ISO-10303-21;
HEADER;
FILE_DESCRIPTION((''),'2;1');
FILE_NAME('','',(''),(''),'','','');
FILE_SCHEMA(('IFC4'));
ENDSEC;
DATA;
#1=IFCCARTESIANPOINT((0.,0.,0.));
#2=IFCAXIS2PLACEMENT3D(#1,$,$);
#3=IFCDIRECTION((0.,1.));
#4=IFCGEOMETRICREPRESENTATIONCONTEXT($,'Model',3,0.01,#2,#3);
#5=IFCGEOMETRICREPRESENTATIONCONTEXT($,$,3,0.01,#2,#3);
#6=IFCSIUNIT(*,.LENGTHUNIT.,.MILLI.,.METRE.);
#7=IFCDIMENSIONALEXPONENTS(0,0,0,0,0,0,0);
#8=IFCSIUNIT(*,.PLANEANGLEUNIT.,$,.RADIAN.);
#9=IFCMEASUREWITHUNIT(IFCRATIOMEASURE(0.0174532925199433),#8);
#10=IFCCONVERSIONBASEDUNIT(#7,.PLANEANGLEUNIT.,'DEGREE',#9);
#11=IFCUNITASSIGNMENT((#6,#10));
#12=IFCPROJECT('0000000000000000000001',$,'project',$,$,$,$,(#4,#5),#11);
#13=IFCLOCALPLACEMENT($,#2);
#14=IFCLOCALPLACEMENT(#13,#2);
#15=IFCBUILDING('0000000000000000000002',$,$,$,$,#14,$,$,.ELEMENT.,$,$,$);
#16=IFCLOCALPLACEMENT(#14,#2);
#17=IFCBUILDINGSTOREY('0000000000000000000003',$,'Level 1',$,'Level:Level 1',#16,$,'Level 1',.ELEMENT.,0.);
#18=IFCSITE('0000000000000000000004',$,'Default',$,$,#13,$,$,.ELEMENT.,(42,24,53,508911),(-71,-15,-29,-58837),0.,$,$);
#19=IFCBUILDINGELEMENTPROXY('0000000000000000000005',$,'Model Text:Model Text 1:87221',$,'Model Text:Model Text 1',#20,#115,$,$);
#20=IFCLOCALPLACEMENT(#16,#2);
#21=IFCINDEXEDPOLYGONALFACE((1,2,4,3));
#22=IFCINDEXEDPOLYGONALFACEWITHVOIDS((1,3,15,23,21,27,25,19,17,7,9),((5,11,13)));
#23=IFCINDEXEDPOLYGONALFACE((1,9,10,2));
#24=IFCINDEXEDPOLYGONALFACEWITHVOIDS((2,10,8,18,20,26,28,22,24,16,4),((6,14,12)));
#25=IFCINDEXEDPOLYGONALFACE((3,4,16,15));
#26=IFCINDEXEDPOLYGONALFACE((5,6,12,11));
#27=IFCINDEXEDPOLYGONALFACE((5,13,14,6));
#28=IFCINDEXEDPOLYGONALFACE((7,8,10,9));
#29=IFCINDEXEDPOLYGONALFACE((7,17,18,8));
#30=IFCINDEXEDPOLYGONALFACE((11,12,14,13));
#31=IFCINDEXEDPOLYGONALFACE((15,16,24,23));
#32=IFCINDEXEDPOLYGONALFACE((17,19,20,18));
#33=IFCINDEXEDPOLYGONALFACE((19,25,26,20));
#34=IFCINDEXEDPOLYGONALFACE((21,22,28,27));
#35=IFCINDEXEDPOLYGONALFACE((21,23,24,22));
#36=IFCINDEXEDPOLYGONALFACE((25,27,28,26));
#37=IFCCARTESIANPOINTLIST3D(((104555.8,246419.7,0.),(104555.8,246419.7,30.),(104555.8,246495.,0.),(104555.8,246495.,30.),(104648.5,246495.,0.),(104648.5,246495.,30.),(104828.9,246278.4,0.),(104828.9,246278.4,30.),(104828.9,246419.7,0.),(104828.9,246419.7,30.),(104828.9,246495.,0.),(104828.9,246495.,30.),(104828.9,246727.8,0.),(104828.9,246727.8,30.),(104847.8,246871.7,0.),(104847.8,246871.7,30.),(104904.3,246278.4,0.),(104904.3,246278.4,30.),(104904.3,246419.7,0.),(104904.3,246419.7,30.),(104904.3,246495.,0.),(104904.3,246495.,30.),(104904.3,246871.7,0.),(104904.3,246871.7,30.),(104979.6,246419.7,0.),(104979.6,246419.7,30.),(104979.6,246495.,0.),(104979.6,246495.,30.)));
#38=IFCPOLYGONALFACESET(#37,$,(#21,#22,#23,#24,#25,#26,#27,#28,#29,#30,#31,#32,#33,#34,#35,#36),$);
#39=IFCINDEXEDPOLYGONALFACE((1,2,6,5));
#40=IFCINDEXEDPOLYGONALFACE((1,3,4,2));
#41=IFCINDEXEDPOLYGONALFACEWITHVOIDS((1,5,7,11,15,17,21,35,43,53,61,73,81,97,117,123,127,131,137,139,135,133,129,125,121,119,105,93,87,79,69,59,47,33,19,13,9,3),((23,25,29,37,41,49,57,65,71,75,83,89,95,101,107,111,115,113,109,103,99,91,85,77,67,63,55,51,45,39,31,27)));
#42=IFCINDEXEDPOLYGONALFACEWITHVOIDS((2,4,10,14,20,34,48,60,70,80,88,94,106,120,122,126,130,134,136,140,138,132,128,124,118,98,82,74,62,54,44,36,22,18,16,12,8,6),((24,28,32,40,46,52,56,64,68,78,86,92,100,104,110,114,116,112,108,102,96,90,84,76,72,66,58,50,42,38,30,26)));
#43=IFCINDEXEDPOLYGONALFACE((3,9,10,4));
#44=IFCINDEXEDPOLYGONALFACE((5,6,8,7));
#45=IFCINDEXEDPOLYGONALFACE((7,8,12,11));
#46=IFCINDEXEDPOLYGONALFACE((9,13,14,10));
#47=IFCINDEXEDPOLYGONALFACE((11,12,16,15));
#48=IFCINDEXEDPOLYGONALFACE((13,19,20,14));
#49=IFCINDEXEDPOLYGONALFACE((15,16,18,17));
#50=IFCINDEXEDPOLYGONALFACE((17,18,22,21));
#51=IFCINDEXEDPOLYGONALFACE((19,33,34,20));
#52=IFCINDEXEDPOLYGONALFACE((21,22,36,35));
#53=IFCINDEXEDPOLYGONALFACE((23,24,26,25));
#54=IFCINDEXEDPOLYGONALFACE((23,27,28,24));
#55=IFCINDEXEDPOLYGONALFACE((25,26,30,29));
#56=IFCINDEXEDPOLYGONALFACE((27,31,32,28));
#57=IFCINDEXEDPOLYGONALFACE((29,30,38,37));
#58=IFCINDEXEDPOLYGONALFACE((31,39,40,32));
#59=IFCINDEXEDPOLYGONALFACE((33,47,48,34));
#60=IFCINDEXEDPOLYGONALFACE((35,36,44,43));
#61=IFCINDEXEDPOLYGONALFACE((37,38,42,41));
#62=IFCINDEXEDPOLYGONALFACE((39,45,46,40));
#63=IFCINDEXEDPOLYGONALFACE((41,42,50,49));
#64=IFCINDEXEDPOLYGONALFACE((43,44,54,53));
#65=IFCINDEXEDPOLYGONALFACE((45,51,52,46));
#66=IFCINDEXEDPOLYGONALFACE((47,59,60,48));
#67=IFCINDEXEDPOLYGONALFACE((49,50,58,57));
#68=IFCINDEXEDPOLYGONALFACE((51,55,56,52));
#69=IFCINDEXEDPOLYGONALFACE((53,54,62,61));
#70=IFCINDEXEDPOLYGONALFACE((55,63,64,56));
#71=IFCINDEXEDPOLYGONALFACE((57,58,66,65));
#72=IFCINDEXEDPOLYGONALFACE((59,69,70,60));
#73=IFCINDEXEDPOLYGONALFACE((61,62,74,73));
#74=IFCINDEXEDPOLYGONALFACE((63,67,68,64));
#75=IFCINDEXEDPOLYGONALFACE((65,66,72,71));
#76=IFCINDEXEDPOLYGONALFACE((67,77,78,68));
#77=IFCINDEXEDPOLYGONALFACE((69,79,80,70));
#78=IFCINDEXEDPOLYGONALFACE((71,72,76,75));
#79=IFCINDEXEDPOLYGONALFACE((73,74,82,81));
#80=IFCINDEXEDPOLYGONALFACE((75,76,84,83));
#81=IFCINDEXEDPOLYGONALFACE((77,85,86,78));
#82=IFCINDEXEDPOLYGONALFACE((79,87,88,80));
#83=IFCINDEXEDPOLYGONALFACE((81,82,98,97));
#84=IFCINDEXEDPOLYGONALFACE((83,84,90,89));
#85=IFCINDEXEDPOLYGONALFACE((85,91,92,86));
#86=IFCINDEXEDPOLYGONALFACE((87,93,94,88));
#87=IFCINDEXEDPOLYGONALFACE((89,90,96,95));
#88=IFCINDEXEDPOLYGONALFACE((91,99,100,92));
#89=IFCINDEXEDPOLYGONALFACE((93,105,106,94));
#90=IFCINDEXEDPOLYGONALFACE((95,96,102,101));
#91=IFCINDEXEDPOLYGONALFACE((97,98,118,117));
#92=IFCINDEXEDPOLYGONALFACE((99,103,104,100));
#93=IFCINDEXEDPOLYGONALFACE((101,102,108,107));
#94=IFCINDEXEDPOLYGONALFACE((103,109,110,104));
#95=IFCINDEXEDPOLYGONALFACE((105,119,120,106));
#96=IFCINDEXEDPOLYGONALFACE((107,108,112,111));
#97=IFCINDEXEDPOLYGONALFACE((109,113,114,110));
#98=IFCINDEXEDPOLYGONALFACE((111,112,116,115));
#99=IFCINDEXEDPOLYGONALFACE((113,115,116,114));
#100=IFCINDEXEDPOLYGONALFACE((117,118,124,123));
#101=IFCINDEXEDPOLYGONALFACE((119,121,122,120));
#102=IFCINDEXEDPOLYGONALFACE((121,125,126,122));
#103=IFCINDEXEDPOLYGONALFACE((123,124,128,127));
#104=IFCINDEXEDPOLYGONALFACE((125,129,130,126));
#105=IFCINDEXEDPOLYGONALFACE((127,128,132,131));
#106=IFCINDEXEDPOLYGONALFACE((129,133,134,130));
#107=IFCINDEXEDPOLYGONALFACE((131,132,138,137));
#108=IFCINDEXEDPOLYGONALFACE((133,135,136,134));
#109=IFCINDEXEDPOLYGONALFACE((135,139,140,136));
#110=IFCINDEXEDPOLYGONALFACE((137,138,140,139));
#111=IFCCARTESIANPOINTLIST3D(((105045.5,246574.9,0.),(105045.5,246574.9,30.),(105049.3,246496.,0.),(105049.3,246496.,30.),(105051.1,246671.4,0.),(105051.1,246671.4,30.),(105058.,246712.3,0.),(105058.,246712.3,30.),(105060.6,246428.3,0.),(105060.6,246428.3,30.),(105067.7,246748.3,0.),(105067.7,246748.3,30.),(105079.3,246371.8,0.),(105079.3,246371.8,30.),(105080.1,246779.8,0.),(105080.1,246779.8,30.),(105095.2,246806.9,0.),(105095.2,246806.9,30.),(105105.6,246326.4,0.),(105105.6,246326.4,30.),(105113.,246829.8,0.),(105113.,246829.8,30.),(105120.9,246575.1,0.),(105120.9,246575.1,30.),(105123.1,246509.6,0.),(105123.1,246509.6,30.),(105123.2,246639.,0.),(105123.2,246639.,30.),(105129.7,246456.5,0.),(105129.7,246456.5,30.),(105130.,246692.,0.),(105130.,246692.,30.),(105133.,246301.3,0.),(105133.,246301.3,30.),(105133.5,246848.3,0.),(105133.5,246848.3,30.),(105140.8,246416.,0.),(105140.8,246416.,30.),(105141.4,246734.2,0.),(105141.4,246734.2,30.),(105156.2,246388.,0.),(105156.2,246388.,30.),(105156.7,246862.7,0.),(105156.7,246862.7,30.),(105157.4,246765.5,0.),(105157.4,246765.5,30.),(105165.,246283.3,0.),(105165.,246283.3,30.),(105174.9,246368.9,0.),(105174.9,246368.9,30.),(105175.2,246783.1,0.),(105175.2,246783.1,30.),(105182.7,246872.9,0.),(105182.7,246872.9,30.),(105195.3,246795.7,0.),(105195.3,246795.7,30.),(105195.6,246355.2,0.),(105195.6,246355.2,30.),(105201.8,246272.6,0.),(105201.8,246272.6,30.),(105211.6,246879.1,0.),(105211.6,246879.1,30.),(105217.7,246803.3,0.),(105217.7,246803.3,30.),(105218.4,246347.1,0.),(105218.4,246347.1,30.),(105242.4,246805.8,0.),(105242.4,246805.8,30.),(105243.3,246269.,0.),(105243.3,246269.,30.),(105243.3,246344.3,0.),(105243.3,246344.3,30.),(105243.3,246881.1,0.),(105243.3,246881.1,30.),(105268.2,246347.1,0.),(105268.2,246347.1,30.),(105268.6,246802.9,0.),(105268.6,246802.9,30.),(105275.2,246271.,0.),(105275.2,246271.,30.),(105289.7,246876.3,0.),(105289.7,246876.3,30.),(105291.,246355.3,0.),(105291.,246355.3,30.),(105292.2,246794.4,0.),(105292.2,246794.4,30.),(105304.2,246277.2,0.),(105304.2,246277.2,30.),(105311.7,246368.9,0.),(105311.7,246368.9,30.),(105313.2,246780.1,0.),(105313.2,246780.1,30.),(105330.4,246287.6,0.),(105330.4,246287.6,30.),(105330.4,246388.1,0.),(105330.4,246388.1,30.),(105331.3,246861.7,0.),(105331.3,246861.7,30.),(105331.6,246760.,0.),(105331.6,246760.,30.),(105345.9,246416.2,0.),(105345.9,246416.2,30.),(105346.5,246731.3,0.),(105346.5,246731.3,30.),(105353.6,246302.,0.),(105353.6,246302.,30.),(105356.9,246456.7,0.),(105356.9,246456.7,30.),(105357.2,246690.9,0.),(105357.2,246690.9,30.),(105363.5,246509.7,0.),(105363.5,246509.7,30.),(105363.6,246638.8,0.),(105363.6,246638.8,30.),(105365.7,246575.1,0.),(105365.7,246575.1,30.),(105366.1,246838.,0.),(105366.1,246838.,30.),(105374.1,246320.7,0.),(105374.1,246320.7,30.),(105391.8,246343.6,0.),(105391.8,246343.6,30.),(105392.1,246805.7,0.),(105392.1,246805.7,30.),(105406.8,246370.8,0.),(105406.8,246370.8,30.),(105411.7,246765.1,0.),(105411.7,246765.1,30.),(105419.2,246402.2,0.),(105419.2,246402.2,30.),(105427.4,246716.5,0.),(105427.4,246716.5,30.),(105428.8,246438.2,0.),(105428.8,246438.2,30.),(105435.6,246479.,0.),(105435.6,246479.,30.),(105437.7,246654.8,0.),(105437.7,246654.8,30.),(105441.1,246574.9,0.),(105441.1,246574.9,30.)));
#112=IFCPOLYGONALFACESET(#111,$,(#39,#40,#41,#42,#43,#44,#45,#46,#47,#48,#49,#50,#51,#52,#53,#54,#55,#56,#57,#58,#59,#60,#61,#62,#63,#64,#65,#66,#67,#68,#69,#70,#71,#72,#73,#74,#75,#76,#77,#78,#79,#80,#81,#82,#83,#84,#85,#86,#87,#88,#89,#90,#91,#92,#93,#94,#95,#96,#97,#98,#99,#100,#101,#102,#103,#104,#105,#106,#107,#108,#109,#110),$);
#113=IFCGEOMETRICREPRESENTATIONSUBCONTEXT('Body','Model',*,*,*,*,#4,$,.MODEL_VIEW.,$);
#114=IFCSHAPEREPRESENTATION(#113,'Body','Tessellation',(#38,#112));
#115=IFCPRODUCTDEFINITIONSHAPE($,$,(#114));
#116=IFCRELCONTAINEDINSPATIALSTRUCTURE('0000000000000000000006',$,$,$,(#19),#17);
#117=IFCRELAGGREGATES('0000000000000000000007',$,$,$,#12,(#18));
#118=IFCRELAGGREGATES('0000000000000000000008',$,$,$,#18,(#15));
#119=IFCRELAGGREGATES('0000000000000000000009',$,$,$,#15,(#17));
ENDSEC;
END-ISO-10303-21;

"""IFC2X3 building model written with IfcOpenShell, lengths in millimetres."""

from ifc_helpers import new_model, entity, si_unit, converted_unit, direction, frame, origin, place, context, subcontext, project, spatial, polyline, outline, extrude, element, save


model = new_model("IFC2X3")

# Units and contexts
model_context = context("Model", 3, precision=0.01, world=origin(), true_north=direction((0.0, 1.0)))
context_of_model = context(None, 3, precision=0.01, world=origin(), true_north=direction((0.0, 1.0)))
body_context = subcontext(model_context, "Body", "Model", "MODEL_VIEW")
ifc_project = project(units=[si_unit("LENGTHUNIT", "METRE", prefix="MILLI"), converted_unit("PLANEANGLEUNIT", "DEGREE", entity("IfcRatioMeasure", 0.0174532925199433), si_unit("PLANEANGLEUNIT", "RADIAN"), dimensions=[0, 0, 0, 0, 0, 0, 0])], contexts=[model_context, context_of_model])

# Site, building, storey
site_placement = place(None, origin())
site = spatial("IfcSite", under=ifc_project, at=site_placement, Name="Default", CompositionType="ELEMENT", RefLatitude=(42, 24, 53, 508911), RefLongitude=(-71, -15, -29, -58837), RefElevation=0.0)
building_placement = place(site_placement, origin())
building = spatial("IfcBuilding", under=site, at=building_placement, CompositionType="ELEMENT")
storey_placement = place(building_placement, origin())
storey = spatial("IfcBuildingStorey", under=building, at=storey_placement, Name="Level 1", ObjectType="Level:Level 1", LongName="Level 1", CompositionType="ELEMENT", Elevation=0.0)

# Building element proxy
proxy_1_placement = place(storey_placement, origin())
element("IfcBuildingElementProxy", 1, at=proxy_1_placement, inside=storey, Name="Model Text:Model Text 1:87221", ObjectType="Model Text:Model Text 1", context=body_context, shape_type="SweptSolid", body=[
    extrude(outline(polyline([(-6.8, -218.3), (68.5, -218.3), (68.5, -77.1), (143.8, -77.1), (143.8, -1.7), (68.5, -1.7), (68.5, 375.0), (12.0, 375.0), (-280.0, -1.7), (-280.0, -77.1), (-6.8, -77.1), (-6.8, -218.3)]), holes=[polyline([(-6.8, -1.7), (-187.3, -1.7), (-6.8, 231.1), (-6.8, -1.7)])]), frame((104835.8, 246496.7, 0.0)), (0.0, 0.0, 1.0), 30.0),
    extrude(outline(polyline([(-10.6, -198.7), (68.3, -198.7), (136.5, -190.7), (193.9, -174.7), (240.5, -150.6), (266.9, -124.4), (286.3, -93.2), (298.8, -57.0), (304.3, -15.7), (303.8, 16.2), (299.0, 45.5), (289.9, 72.1), (276.6, 96.0), (258.9, 117.3), (236.9, 136.2), (210.4, 152.5), (179.6, 166.3), (144.1, 177.6), (103.7, 186.3), (8.2, 196.4), (-71.8, 196.7), (-134.0, 189.4), (-183.3, 176.1), (-224.7, 158.4), (-258.2, 133.9), (-283.5, 100.3), (-300.1, 59.5), (-307.1, 13.4), (-306.6, -18.4), (-301.8, -47.5), (-292.8, -74.0), (-279.6, -97.9), (-262.0, -119.2), (-240.0, -138.1), (-213.6, -154.5), (-182.8, -168.4), (-147.3, -179.8), (-106.7, -188.6), (-10.6, -198.7)]), holes=[polyline([(-7.2, -123.5), (-71.0, -118.2), (-123.6, -108.8), (-165.2, -95.4), (-195.7, -78.0), (-212.4, -59.4), (-224.1, -38.7), (-230.6, -15.9), (-231.9, 8.9), (-227.8, 35.0), (-218.1, 58.1), (-202.8, 78.4), (-182.0, 95.8), (-152.6, 109.4), (-111.7, 118.1), (-59.4, 122.0), (4.4, 121.1), (69.6, 115.8), (122.2, 106.7), (162.2, 93.7), (189.5, 77.0), (207.7, 57.4), (220.4, 36.0), (227.5, 12.8), (229.1, -12.1), (225.2, -36.8), (215.9, -59.2), (201.3, -79.3), (181.4, -97.1), (152.6, -111.2), (111.6, -120.3), (58.3, -124.4), (-7.2, -123.5)])]), frame((105244.6, 246573.7, 0.0), z_axis=(0.0, 0.0, 1.0), x_axis=(0.047515, -0.998871, 0.0)), (0.0, 0.0, 1.0), 30.0),
])

save(model, "model.ifc")
